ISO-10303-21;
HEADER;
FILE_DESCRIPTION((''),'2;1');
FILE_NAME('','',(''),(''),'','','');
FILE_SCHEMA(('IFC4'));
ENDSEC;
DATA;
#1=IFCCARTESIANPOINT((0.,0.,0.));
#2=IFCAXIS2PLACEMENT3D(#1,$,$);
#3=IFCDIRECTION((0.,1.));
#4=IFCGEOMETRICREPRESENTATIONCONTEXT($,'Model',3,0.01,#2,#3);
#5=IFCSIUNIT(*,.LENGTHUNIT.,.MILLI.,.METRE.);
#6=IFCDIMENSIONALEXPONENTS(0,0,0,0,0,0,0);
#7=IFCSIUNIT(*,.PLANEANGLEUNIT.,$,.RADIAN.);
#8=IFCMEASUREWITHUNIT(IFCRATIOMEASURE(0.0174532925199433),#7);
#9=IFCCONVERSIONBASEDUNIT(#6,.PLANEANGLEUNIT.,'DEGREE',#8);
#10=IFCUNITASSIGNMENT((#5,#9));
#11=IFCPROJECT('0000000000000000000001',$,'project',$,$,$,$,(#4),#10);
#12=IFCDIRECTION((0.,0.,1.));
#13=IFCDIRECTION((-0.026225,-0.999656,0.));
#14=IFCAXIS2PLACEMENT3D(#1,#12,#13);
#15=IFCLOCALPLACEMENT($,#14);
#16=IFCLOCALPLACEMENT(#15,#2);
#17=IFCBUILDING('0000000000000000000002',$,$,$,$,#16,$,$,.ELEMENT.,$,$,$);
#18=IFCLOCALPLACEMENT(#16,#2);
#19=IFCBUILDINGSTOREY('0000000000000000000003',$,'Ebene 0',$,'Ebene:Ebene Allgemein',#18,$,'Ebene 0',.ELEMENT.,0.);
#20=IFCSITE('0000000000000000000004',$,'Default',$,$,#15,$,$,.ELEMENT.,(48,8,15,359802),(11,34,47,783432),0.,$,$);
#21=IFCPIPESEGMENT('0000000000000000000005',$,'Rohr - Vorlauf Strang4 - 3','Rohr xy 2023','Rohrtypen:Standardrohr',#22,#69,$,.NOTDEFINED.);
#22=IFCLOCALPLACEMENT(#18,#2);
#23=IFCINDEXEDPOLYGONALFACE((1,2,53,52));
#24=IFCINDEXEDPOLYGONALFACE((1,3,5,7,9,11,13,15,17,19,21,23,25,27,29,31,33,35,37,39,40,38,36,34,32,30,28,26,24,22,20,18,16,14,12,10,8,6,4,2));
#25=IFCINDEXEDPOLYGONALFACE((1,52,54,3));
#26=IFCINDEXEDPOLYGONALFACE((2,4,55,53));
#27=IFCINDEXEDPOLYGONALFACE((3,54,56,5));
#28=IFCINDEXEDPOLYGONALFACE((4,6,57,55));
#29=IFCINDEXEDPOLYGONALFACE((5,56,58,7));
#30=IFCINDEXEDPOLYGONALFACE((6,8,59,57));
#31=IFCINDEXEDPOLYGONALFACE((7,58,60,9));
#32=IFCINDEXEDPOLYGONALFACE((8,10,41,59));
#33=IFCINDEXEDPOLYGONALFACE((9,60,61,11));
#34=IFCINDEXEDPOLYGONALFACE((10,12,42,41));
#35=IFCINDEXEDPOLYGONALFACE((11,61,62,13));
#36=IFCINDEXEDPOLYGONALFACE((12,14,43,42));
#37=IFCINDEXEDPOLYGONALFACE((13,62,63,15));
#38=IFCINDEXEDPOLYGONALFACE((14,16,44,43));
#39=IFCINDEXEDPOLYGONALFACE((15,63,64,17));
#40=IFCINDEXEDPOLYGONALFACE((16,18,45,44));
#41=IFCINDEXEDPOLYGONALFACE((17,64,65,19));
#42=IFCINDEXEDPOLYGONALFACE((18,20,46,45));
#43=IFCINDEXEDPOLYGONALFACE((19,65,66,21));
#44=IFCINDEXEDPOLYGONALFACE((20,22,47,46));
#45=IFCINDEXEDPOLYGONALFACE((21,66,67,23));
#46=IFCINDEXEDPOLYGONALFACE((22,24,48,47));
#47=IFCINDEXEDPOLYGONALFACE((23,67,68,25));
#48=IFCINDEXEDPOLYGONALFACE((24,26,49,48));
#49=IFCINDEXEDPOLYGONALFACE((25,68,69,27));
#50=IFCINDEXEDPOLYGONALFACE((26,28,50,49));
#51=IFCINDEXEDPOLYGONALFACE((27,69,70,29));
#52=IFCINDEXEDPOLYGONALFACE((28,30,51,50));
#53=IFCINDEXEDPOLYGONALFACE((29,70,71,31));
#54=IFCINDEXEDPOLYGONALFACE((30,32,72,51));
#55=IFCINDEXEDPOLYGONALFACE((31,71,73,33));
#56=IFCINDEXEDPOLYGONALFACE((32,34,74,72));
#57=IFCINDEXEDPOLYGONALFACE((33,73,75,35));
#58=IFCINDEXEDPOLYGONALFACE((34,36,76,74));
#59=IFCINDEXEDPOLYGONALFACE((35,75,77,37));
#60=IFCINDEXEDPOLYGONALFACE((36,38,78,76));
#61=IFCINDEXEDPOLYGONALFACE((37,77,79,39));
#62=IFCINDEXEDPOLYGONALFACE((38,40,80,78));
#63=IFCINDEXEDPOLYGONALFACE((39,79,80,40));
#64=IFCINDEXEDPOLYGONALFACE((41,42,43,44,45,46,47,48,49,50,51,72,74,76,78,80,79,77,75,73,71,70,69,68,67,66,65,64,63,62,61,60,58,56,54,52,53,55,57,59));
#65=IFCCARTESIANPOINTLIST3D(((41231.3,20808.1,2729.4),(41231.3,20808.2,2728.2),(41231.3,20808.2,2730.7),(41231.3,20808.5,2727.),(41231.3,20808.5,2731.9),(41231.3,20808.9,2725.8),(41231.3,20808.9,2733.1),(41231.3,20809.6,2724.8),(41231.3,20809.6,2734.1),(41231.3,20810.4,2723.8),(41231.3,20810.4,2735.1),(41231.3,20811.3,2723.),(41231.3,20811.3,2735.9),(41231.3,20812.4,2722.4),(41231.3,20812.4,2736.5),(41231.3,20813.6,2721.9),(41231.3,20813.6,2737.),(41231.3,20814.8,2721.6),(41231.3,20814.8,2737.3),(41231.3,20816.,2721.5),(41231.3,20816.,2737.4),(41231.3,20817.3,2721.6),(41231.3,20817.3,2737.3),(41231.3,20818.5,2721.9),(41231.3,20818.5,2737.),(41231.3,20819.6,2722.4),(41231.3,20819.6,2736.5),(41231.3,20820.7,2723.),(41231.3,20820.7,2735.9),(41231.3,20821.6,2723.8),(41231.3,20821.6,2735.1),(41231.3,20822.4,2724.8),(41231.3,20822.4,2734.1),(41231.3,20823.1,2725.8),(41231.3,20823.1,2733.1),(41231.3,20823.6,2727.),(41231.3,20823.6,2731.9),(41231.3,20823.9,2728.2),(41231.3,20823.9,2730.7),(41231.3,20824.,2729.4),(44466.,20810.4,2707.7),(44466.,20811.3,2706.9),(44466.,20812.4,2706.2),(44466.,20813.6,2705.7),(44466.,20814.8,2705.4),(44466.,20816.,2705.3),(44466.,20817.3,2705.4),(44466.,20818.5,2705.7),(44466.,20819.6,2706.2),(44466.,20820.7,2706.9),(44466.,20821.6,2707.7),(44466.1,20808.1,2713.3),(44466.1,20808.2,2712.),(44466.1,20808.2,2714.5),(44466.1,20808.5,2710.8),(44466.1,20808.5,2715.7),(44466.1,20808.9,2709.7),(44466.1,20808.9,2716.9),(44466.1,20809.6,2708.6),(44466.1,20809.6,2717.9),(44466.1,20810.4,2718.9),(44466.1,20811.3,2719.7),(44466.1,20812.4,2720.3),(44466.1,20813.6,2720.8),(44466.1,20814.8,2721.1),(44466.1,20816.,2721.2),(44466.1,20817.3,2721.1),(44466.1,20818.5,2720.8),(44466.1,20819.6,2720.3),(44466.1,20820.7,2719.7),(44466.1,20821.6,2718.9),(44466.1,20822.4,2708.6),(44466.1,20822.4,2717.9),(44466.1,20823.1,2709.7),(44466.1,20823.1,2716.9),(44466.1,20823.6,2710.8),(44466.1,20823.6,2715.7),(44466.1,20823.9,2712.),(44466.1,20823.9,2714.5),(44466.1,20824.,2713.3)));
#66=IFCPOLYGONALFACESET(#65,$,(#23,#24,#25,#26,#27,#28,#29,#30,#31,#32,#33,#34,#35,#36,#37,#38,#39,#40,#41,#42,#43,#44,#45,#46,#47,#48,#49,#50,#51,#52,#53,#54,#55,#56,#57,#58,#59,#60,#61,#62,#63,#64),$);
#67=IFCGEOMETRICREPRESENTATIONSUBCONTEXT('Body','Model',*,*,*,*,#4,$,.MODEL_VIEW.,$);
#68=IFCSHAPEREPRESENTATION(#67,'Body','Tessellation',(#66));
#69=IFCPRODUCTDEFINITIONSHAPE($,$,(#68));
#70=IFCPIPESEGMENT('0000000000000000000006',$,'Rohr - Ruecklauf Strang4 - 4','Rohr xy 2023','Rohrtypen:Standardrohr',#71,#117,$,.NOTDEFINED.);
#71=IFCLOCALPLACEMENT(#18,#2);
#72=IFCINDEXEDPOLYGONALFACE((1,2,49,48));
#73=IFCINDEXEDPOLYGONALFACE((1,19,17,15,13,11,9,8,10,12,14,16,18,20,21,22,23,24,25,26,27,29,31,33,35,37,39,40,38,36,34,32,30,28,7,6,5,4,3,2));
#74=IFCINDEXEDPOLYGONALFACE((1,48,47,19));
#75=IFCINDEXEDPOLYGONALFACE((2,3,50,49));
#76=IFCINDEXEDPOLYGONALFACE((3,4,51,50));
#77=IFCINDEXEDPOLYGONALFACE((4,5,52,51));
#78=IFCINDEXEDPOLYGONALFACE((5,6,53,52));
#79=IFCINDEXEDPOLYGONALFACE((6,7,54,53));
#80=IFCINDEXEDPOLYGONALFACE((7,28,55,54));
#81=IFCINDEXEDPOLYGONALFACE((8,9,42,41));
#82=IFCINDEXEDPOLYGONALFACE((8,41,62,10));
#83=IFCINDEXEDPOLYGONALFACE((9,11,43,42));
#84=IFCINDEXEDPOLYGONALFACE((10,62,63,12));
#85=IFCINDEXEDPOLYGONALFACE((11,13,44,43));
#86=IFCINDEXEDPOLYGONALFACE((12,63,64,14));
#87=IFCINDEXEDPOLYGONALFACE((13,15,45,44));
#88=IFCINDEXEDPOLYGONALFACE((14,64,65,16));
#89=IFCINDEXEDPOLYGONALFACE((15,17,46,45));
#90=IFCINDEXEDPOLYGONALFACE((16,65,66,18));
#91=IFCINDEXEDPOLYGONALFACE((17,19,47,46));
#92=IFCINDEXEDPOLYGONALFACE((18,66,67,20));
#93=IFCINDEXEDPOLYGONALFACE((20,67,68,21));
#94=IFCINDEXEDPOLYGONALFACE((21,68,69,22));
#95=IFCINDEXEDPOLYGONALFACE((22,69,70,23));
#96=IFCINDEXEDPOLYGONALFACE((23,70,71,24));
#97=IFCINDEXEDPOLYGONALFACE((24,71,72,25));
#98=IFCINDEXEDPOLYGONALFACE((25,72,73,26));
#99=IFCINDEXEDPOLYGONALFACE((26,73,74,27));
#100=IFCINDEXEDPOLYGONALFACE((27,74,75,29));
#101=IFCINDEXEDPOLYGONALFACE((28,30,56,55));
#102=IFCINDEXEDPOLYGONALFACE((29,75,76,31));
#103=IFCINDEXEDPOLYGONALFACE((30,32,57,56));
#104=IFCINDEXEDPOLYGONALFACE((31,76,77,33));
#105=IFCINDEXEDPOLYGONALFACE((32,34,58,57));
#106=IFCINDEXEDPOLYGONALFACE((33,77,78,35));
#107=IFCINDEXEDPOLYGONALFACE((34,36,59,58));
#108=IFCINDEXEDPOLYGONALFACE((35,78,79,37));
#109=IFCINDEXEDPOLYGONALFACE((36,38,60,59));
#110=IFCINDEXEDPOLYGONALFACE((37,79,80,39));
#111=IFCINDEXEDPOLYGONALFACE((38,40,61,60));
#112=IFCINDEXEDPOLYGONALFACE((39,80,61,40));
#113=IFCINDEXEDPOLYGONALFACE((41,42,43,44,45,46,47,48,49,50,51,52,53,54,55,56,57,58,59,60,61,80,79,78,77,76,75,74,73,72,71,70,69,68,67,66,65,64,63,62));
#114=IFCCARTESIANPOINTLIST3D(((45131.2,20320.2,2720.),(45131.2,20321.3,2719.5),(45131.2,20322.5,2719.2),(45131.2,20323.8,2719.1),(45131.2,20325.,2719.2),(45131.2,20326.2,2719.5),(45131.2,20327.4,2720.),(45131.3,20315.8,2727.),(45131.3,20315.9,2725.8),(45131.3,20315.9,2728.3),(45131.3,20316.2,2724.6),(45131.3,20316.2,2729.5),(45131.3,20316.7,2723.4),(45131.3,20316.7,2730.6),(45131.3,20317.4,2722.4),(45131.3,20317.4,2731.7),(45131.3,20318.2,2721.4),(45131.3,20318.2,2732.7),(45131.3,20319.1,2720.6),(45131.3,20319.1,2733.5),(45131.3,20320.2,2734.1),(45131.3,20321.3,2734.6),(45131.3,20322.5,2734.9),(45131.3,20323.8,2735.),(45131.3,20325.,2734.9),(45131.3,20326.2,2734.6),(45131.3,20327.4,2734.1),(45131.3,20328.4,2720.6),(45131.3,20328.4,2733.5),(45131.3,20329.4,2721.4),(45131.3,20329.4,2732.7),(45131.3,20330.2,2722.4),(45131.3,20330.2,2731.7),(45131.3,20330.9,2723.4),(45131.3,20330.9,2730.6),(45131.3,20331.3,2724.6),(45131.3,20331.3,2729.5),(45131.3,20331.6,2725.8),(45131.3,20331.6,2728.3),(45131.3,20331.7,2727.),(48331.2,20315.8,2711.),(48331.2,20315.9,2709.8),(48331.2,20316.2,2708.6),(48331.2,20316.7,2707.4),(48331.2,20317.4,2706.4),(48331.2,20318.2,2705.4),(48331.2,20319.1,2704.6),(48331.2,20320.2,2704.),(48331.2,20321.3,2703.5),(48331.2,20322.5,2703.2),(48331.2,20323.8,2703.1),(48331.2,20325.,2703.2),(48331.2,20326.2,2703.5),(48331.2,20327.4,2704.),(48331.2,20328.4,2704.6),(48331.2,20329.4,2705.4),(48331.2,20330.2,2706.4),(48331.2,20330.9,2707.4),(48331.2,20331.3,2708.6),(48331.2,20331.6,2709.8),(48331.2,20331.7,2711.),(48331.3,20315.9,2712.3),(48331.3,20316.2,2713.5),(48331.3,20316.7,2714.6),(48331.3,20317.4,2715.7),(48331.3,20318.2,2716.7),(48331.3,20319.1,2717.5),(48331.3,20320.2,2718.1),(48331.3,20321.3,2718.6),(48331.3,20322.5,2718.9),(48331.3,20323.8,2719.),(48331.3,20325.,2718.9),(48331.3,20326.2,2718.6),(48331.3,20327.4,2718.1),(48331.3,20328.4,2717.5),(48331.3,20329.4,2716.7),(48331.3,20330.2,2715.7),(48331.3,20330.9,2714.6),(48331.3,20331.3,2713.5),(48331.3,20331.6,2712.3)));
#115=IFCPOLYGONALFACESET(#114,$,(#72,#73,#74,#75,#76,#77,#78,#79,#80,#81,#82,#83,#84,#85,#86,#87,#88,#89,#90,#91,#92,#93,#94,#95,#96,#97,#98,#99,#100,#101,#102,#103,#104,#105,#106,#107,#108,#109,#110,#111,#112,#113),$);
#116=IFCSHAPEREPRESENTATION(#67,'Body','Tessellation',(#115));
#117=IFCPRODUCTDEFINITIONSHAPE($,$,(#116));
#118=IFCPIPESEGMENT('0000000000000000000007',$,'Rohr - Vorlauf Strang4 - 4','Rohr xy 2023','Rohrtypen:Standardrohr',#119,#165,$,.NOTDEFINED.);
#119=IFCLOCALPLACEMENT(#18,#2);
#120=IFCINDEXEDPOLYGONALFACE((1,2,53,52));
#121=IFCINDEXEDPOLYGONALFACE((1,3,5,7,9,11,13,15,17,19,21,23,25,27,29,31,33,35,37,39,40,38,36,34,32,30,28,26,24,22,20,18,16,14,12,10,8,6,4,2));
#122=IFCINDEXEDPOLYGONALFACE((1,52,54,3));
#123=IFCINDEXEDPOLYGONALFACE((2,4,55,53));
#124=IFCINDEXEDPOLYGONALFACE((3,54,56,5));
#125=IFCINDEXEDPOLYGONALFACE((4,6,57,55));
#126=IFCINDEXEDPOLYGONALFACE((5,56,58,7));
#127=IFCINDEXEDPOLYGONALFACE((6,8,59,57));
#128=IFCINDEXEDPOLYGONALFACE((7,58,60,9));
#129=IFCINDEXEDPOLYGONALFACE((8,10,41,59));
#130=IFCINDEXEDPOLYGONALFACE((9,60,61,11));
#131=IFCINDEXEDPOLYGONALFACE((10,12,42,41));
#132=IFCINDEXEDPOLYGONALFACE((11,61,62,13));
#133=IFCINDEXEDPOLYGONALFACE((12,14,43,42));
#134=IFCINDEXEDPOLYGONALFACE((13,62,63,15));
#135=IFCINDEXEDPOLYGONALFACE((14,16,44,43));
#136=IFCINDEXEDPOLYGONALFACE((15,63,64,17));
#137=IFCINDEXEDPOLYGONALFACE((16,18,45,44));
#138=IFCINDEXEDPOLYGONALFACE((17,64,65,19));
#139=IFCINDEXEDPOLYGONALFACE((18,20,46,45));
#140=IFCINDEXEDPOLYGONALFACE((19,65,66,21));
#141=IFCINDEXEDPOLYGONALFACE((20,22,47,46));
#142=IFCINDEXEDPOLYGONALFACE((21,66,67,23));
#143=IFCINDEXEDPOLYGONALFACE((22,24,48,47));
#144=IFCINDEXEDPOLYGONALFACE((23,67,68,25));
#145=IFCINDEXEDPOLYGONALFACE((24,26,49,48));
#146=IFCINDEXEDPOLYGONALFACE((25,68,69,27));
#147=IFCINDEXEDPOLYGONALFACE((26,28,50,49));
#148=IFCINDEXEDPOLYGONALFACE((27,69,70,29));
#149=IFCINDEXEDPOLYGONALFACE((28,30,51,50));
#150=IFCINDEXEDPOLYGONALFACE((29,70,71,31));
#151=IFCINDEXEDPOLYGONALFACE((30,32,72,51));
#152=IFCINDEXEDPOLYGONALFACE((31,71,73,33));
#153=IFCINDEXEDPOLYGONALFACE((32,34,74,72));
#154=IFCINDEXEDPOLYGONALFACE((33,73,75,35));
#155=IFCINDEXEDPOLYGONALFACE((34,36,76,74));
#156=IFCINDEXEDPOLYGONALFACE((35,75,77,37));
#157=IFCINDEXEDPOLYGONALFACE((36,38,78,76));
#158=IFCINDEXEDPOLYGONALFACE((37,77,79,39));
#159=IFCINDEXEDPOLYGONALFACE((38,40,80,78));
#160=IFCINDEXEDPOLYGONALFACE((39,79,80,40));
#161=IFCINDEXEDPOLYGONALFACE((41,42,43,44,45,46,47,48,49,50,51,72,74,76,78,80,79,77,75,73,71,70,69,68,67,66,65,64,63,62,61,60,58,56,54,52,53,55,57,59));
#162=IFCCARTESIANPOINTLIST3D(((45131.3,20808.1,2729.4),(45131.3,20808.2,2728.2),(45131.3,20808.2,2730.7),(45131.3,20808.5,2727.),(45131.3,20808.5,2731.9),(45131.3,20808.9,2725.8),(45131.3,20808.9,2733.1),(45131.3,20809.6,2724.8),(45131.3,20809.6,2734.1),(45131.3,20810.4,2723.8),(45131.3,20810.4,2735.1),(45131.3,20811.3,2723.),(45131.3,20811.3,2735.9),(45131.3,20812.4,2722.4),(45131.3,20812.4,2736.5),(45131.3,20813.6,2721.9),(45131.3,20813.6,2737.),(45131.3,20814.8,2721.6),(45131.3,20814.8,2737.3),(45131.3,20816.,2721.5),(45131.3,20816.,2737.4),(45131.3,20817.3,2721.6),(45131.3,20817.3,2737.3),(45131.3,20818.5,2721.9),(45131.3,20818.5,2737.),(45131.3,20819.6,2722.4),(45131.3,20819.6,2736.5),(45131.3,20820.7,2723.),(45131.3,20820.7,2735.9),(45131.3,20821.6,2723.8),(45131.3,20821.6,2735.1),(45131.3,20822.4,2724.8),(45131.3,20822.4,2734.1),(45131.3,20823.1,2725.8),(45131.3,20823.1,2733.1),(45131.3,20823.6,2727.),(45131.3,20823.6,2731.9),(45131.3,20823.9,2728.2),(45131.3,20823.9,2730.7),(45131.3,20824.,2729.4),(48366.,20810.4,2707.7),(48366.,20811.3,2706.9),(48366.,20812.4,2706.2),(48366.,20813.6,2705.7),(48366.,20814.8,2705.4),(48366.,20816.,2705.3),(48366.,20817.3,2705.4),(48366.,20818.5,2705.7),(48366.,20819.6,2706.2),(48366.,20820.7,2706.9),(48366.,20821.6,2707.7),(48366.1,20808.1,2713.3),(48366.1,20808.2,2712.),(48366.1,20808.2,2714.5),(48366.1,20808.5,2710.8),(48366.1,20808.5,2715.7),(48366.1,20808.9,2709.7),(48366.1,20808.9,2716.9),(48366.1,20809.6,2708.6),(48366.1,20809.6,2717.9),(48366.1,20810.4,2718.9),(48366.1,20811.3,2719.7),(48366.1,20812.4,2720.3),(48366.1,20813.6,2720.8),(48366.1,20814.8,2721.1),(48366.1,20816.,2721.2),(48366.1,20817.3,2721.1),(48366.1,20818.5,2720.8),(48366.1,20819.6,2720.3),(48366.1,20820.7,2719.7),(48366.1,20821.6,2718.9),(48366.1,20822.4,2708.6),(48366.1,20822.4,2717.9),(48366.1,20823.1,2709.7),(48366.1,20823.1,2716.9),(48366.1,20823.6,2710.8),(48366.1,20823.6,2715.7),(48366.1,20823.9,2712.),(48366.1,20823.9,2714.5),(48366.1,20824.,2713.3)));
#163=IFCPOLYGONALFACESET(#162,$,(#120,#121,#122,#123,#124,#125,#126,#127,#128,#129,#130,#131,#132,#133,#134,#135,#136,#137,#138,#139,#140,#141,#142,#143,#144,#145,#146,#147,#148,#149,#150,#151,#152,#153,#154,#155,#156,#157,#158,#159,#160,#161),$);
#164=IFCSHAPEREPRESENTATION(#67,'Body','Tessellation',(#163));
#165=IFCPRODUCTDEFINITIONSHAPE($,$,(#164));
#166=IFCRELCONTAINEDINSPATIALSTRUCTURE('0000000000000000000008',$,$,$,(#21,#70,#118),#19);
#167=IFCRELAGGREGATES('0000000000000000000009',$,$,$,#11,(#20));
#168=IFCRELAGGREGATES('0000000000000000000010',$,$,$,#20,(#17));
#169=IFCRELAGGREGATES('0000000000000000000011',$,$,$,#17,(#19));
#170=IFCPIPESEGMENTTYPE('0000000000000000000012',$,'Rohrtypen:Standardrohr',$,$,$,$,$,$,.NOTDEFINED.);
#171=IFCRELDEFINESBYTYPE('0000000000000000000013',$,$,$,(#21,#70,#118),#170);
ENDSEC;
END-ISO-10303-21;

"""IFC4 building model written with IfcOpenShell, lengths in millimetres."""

from ifc_helpers import new_model, entity, si_unit, converted_unit, direction, frame, origin, place, context, subcontext, project, spatial, indexed_curve, outline, extrude, type_object, element, save


model = new_model("IFC4")

# Units and contexts
model_context = context("Model", 3, precision=0.01, world=origin(), true_north=direction((0.0, 1.0)))
body_context = subcontext(model_context, "Body", "Model", "MODEL_VIEW")
ifc_project = project(units=[si_unit("LENGTHUNIT", "METRE", prefix="MILLI"), converted_unit("PLANEANGLEUNIT", "DEGREE", entity("IfcRatioMeasure", 0.0174532925199433), si_unit("PLANEANGLEUNIT", "RADIAN"), dimensions=[0, 0, 0, 0, 0, 0, 0])], contexts=[model_context])

# Site, building, storey
site_placement = place(None, frame((0.0, 0.0, 0.0), z_axis=(0.0, 0.0, 1.0), x_axis=(-0.026225, -0.999656, 0.0)))
site = spatial("IfcSite", under=ifc_project, at=site_placement, Name="Default", CompositionType="ELEMENT", RefLatitude=(48, 8, 15, 359802), RefLongitude=(11, 34, 47, 783432), RefElevation=0.0)
building_placement = place(site_placement, origin())
building = spatial("IfcBuilding", under=site, at=building_placement, CompositionType="ELEMENT")
storey_placement = place(building_placement, origin())
storey = spatial("IfcBuildingStorey", under=building, at=storey_placement, Name="Ebene 0", ObjectType="Ebene:Ebene Allgemein", LongName="Ebene 0", CompositionType="ELEMENT", Elevation=0.0)

# Pipe segments
pipe_segment_type = type_object("IfcPipeSegmentType", Name="Rohrtypen:Standardrohr", PredefinedType="NOTDEFINED")
pipe_segment_1_placement = place(storey_placement, origin())
element("IfcPipeSegment", 1, at=pipe_segment_1_placement, inside=storey, type_object=pipe_segment_type, Name="Rohr - Vorlauf Strang4 - 3", Description="Rohr xy 2023", ObjectType="Rohrtypen:Standardrohr", PredefinedType="NOTDEFINED", context=body_context, shape_type="SweptSolid", body=[
    extrude(outline(indexed_curve([(7.9, 0.0), (7.8, 1.2), (7.6, 2.5), (7.1, 3.6), (6.4, 4.7), (5.6, 5.6), (4.7, 6.4), (3.6, 7.1), (2.5, 7.6), (1.2, 7.8), (0.0, 7.9), (-1.2, 7.8), (-2.5, 7.6), (-3.6, 7.1), (-4.7, 6.4), (-5.6, 5.6), (-6.4, 4.7), (-7.1, 3.6), (-7.6, 2.5), (-7.8, 1.2), (-7.9, 0.0), (-7.8, -1.2), (-7.6, -2.5), (-7.1, -3.6), (-6.4, -4.7), (-5.6, -5.6), (-4.7, -6.4), (-3.6, -7.1), (-2.5, -7.6), (-1.2, -7.8), (0.0, -7.9), (1.2, -7.8), (2.5, -7.6), (3.6, -7.1), (4.7, -6.4), (5.6, -5.6), (6.4, -4.7), (7.1, -3.6), (7.6, -2.5), (7.8, -1.2), (7.9, 0.0)], self_intersect=False)), frame((44466.1, 20816.0, 2713.3), z_axis=(-0.999988, 0.0, 0.005), x_axis=(0.0, 1.0, 0.0)), (0.0, 0.0, 1.0), 3234.8),
])
pipe_segment_2_placement = place(storey_placement, origin())
element("IfcPipeSegment", 2, at=pipe_segment_2_placement, inside=storey, type_object=pipe_segment_type, Name="Rohr - Ruecklauf Strang4 - 4", Description="Rohr xy 2023", ObjectType="Rohrtypen:Standardrohr", PredefinedType="NOTDEFINED", context=body_context, shape_type="SweptSolid", body=[
    extrude(outline(indexed_curve([(7.9, 0.0), (7.8, 1.2), (7.6, 2.5), (7.1, 3.6), (6.4, 4.7), (5.6, 5.6), (4.7, 6.4), (3.6, 7.1), (2.5, 7.6), (1.2, 7.8), (0.0, 7.9), (-1.2, 7.8), (-2.5, 7.6), (-3.6, 7.1), (-4.7, 6.4), (-5.6, 5.6), (-6.4, 4.7), (-7.1, 3.6), (-7.6, 2.5), (-7.8, 1.2), (-7.9, 0.0), (-7.8, -1.2), (-7.6, -2.5), (-7.1, -3.6), (-6.4, -4.7), (-5.6, -5.6), (-4.7, -6.4), (-3.6, -7.1), (-2.5, -7.6), (-1.2, -7.8), (0.0, -7.9), (1.2, -7.8), (2.5, -7.6), (3.6, -7.1), (4.7, -6.4), (5.6, -5.6), (6.4, -4.7), (7.1, -3.6), (7.6, -2.5), (7.8, -1.2), (7.9, 0.0)], self_intersect=False)), frame((48331.2, 20323.8, 2711.0), z_axis=(-0.999988, 0.0, 0.005), x_axis=(0.0, 1.0, 0.0)), (0.0, 0.0, 1.0), 3200.0),
])
pipe_segment_3_placement = place(storey_placement, origin())
element("IfcPipeSegment", 3, at=pipe_segment_3_placement, inside=storey, type_object=pipe_segment_type, Name="Rohr - Vorlauf Strang4 - 4", Description="Rohr xy 2023", ObjectType="Rohrtypen:Standardrohr", PredefinedType="NOTDEFINED", context=body_context, shape_type="SweptSolid", body=[
    extrude(outline(indexed_curve([(7.9, 0.0), (7.8, 1.2), (7.6, 2.5), (7.1, 3.6), (6.4, 4.7), (5.6, 5.6), (4.7, 6.4), (3.6, 7.1), (2.5, 7.6), (1.2, 7.8), (0.0, 7.9), (-1.2, 7.8), (-2.5, 7.6), (-3.6, 7.1), (-4.7, 6.4), (-5.6, 5.6), (-6.4, 4.7), (-7.1, 3.6), (-7.6, 2.5), (-7.8, 1.2), (-7.9, 0.0), (-7.8, -1.2), (-7.6, -2.5), (-7.1, -3.6), (-6.4, -4.7), (-5.6, -5.6), (-4.7, -6.4), (-3.6, -7.1), (-2.5, -7.6), (-1.2, -7.8), (0.0, -7.9), (1.2, -7.8), (2.5, -7.6), (3.6, -7.1), (4.7, -6.4), (5.6, -5.6), (6.4, -4.7), (7.1, -3.6), (7.6, -2.5), (7.8, -1.2), (7.9, 0.0)], self_intersect=False)), frame((48366.1, 20816.0, 2713.3), z_axis=(-0.999988, 0.0, 0.005), x_axis=(0.0, 1.0, 0.0)), (0.0, 0.0, 1.0), 3234.8),
])

save(model, "model.ifc")
